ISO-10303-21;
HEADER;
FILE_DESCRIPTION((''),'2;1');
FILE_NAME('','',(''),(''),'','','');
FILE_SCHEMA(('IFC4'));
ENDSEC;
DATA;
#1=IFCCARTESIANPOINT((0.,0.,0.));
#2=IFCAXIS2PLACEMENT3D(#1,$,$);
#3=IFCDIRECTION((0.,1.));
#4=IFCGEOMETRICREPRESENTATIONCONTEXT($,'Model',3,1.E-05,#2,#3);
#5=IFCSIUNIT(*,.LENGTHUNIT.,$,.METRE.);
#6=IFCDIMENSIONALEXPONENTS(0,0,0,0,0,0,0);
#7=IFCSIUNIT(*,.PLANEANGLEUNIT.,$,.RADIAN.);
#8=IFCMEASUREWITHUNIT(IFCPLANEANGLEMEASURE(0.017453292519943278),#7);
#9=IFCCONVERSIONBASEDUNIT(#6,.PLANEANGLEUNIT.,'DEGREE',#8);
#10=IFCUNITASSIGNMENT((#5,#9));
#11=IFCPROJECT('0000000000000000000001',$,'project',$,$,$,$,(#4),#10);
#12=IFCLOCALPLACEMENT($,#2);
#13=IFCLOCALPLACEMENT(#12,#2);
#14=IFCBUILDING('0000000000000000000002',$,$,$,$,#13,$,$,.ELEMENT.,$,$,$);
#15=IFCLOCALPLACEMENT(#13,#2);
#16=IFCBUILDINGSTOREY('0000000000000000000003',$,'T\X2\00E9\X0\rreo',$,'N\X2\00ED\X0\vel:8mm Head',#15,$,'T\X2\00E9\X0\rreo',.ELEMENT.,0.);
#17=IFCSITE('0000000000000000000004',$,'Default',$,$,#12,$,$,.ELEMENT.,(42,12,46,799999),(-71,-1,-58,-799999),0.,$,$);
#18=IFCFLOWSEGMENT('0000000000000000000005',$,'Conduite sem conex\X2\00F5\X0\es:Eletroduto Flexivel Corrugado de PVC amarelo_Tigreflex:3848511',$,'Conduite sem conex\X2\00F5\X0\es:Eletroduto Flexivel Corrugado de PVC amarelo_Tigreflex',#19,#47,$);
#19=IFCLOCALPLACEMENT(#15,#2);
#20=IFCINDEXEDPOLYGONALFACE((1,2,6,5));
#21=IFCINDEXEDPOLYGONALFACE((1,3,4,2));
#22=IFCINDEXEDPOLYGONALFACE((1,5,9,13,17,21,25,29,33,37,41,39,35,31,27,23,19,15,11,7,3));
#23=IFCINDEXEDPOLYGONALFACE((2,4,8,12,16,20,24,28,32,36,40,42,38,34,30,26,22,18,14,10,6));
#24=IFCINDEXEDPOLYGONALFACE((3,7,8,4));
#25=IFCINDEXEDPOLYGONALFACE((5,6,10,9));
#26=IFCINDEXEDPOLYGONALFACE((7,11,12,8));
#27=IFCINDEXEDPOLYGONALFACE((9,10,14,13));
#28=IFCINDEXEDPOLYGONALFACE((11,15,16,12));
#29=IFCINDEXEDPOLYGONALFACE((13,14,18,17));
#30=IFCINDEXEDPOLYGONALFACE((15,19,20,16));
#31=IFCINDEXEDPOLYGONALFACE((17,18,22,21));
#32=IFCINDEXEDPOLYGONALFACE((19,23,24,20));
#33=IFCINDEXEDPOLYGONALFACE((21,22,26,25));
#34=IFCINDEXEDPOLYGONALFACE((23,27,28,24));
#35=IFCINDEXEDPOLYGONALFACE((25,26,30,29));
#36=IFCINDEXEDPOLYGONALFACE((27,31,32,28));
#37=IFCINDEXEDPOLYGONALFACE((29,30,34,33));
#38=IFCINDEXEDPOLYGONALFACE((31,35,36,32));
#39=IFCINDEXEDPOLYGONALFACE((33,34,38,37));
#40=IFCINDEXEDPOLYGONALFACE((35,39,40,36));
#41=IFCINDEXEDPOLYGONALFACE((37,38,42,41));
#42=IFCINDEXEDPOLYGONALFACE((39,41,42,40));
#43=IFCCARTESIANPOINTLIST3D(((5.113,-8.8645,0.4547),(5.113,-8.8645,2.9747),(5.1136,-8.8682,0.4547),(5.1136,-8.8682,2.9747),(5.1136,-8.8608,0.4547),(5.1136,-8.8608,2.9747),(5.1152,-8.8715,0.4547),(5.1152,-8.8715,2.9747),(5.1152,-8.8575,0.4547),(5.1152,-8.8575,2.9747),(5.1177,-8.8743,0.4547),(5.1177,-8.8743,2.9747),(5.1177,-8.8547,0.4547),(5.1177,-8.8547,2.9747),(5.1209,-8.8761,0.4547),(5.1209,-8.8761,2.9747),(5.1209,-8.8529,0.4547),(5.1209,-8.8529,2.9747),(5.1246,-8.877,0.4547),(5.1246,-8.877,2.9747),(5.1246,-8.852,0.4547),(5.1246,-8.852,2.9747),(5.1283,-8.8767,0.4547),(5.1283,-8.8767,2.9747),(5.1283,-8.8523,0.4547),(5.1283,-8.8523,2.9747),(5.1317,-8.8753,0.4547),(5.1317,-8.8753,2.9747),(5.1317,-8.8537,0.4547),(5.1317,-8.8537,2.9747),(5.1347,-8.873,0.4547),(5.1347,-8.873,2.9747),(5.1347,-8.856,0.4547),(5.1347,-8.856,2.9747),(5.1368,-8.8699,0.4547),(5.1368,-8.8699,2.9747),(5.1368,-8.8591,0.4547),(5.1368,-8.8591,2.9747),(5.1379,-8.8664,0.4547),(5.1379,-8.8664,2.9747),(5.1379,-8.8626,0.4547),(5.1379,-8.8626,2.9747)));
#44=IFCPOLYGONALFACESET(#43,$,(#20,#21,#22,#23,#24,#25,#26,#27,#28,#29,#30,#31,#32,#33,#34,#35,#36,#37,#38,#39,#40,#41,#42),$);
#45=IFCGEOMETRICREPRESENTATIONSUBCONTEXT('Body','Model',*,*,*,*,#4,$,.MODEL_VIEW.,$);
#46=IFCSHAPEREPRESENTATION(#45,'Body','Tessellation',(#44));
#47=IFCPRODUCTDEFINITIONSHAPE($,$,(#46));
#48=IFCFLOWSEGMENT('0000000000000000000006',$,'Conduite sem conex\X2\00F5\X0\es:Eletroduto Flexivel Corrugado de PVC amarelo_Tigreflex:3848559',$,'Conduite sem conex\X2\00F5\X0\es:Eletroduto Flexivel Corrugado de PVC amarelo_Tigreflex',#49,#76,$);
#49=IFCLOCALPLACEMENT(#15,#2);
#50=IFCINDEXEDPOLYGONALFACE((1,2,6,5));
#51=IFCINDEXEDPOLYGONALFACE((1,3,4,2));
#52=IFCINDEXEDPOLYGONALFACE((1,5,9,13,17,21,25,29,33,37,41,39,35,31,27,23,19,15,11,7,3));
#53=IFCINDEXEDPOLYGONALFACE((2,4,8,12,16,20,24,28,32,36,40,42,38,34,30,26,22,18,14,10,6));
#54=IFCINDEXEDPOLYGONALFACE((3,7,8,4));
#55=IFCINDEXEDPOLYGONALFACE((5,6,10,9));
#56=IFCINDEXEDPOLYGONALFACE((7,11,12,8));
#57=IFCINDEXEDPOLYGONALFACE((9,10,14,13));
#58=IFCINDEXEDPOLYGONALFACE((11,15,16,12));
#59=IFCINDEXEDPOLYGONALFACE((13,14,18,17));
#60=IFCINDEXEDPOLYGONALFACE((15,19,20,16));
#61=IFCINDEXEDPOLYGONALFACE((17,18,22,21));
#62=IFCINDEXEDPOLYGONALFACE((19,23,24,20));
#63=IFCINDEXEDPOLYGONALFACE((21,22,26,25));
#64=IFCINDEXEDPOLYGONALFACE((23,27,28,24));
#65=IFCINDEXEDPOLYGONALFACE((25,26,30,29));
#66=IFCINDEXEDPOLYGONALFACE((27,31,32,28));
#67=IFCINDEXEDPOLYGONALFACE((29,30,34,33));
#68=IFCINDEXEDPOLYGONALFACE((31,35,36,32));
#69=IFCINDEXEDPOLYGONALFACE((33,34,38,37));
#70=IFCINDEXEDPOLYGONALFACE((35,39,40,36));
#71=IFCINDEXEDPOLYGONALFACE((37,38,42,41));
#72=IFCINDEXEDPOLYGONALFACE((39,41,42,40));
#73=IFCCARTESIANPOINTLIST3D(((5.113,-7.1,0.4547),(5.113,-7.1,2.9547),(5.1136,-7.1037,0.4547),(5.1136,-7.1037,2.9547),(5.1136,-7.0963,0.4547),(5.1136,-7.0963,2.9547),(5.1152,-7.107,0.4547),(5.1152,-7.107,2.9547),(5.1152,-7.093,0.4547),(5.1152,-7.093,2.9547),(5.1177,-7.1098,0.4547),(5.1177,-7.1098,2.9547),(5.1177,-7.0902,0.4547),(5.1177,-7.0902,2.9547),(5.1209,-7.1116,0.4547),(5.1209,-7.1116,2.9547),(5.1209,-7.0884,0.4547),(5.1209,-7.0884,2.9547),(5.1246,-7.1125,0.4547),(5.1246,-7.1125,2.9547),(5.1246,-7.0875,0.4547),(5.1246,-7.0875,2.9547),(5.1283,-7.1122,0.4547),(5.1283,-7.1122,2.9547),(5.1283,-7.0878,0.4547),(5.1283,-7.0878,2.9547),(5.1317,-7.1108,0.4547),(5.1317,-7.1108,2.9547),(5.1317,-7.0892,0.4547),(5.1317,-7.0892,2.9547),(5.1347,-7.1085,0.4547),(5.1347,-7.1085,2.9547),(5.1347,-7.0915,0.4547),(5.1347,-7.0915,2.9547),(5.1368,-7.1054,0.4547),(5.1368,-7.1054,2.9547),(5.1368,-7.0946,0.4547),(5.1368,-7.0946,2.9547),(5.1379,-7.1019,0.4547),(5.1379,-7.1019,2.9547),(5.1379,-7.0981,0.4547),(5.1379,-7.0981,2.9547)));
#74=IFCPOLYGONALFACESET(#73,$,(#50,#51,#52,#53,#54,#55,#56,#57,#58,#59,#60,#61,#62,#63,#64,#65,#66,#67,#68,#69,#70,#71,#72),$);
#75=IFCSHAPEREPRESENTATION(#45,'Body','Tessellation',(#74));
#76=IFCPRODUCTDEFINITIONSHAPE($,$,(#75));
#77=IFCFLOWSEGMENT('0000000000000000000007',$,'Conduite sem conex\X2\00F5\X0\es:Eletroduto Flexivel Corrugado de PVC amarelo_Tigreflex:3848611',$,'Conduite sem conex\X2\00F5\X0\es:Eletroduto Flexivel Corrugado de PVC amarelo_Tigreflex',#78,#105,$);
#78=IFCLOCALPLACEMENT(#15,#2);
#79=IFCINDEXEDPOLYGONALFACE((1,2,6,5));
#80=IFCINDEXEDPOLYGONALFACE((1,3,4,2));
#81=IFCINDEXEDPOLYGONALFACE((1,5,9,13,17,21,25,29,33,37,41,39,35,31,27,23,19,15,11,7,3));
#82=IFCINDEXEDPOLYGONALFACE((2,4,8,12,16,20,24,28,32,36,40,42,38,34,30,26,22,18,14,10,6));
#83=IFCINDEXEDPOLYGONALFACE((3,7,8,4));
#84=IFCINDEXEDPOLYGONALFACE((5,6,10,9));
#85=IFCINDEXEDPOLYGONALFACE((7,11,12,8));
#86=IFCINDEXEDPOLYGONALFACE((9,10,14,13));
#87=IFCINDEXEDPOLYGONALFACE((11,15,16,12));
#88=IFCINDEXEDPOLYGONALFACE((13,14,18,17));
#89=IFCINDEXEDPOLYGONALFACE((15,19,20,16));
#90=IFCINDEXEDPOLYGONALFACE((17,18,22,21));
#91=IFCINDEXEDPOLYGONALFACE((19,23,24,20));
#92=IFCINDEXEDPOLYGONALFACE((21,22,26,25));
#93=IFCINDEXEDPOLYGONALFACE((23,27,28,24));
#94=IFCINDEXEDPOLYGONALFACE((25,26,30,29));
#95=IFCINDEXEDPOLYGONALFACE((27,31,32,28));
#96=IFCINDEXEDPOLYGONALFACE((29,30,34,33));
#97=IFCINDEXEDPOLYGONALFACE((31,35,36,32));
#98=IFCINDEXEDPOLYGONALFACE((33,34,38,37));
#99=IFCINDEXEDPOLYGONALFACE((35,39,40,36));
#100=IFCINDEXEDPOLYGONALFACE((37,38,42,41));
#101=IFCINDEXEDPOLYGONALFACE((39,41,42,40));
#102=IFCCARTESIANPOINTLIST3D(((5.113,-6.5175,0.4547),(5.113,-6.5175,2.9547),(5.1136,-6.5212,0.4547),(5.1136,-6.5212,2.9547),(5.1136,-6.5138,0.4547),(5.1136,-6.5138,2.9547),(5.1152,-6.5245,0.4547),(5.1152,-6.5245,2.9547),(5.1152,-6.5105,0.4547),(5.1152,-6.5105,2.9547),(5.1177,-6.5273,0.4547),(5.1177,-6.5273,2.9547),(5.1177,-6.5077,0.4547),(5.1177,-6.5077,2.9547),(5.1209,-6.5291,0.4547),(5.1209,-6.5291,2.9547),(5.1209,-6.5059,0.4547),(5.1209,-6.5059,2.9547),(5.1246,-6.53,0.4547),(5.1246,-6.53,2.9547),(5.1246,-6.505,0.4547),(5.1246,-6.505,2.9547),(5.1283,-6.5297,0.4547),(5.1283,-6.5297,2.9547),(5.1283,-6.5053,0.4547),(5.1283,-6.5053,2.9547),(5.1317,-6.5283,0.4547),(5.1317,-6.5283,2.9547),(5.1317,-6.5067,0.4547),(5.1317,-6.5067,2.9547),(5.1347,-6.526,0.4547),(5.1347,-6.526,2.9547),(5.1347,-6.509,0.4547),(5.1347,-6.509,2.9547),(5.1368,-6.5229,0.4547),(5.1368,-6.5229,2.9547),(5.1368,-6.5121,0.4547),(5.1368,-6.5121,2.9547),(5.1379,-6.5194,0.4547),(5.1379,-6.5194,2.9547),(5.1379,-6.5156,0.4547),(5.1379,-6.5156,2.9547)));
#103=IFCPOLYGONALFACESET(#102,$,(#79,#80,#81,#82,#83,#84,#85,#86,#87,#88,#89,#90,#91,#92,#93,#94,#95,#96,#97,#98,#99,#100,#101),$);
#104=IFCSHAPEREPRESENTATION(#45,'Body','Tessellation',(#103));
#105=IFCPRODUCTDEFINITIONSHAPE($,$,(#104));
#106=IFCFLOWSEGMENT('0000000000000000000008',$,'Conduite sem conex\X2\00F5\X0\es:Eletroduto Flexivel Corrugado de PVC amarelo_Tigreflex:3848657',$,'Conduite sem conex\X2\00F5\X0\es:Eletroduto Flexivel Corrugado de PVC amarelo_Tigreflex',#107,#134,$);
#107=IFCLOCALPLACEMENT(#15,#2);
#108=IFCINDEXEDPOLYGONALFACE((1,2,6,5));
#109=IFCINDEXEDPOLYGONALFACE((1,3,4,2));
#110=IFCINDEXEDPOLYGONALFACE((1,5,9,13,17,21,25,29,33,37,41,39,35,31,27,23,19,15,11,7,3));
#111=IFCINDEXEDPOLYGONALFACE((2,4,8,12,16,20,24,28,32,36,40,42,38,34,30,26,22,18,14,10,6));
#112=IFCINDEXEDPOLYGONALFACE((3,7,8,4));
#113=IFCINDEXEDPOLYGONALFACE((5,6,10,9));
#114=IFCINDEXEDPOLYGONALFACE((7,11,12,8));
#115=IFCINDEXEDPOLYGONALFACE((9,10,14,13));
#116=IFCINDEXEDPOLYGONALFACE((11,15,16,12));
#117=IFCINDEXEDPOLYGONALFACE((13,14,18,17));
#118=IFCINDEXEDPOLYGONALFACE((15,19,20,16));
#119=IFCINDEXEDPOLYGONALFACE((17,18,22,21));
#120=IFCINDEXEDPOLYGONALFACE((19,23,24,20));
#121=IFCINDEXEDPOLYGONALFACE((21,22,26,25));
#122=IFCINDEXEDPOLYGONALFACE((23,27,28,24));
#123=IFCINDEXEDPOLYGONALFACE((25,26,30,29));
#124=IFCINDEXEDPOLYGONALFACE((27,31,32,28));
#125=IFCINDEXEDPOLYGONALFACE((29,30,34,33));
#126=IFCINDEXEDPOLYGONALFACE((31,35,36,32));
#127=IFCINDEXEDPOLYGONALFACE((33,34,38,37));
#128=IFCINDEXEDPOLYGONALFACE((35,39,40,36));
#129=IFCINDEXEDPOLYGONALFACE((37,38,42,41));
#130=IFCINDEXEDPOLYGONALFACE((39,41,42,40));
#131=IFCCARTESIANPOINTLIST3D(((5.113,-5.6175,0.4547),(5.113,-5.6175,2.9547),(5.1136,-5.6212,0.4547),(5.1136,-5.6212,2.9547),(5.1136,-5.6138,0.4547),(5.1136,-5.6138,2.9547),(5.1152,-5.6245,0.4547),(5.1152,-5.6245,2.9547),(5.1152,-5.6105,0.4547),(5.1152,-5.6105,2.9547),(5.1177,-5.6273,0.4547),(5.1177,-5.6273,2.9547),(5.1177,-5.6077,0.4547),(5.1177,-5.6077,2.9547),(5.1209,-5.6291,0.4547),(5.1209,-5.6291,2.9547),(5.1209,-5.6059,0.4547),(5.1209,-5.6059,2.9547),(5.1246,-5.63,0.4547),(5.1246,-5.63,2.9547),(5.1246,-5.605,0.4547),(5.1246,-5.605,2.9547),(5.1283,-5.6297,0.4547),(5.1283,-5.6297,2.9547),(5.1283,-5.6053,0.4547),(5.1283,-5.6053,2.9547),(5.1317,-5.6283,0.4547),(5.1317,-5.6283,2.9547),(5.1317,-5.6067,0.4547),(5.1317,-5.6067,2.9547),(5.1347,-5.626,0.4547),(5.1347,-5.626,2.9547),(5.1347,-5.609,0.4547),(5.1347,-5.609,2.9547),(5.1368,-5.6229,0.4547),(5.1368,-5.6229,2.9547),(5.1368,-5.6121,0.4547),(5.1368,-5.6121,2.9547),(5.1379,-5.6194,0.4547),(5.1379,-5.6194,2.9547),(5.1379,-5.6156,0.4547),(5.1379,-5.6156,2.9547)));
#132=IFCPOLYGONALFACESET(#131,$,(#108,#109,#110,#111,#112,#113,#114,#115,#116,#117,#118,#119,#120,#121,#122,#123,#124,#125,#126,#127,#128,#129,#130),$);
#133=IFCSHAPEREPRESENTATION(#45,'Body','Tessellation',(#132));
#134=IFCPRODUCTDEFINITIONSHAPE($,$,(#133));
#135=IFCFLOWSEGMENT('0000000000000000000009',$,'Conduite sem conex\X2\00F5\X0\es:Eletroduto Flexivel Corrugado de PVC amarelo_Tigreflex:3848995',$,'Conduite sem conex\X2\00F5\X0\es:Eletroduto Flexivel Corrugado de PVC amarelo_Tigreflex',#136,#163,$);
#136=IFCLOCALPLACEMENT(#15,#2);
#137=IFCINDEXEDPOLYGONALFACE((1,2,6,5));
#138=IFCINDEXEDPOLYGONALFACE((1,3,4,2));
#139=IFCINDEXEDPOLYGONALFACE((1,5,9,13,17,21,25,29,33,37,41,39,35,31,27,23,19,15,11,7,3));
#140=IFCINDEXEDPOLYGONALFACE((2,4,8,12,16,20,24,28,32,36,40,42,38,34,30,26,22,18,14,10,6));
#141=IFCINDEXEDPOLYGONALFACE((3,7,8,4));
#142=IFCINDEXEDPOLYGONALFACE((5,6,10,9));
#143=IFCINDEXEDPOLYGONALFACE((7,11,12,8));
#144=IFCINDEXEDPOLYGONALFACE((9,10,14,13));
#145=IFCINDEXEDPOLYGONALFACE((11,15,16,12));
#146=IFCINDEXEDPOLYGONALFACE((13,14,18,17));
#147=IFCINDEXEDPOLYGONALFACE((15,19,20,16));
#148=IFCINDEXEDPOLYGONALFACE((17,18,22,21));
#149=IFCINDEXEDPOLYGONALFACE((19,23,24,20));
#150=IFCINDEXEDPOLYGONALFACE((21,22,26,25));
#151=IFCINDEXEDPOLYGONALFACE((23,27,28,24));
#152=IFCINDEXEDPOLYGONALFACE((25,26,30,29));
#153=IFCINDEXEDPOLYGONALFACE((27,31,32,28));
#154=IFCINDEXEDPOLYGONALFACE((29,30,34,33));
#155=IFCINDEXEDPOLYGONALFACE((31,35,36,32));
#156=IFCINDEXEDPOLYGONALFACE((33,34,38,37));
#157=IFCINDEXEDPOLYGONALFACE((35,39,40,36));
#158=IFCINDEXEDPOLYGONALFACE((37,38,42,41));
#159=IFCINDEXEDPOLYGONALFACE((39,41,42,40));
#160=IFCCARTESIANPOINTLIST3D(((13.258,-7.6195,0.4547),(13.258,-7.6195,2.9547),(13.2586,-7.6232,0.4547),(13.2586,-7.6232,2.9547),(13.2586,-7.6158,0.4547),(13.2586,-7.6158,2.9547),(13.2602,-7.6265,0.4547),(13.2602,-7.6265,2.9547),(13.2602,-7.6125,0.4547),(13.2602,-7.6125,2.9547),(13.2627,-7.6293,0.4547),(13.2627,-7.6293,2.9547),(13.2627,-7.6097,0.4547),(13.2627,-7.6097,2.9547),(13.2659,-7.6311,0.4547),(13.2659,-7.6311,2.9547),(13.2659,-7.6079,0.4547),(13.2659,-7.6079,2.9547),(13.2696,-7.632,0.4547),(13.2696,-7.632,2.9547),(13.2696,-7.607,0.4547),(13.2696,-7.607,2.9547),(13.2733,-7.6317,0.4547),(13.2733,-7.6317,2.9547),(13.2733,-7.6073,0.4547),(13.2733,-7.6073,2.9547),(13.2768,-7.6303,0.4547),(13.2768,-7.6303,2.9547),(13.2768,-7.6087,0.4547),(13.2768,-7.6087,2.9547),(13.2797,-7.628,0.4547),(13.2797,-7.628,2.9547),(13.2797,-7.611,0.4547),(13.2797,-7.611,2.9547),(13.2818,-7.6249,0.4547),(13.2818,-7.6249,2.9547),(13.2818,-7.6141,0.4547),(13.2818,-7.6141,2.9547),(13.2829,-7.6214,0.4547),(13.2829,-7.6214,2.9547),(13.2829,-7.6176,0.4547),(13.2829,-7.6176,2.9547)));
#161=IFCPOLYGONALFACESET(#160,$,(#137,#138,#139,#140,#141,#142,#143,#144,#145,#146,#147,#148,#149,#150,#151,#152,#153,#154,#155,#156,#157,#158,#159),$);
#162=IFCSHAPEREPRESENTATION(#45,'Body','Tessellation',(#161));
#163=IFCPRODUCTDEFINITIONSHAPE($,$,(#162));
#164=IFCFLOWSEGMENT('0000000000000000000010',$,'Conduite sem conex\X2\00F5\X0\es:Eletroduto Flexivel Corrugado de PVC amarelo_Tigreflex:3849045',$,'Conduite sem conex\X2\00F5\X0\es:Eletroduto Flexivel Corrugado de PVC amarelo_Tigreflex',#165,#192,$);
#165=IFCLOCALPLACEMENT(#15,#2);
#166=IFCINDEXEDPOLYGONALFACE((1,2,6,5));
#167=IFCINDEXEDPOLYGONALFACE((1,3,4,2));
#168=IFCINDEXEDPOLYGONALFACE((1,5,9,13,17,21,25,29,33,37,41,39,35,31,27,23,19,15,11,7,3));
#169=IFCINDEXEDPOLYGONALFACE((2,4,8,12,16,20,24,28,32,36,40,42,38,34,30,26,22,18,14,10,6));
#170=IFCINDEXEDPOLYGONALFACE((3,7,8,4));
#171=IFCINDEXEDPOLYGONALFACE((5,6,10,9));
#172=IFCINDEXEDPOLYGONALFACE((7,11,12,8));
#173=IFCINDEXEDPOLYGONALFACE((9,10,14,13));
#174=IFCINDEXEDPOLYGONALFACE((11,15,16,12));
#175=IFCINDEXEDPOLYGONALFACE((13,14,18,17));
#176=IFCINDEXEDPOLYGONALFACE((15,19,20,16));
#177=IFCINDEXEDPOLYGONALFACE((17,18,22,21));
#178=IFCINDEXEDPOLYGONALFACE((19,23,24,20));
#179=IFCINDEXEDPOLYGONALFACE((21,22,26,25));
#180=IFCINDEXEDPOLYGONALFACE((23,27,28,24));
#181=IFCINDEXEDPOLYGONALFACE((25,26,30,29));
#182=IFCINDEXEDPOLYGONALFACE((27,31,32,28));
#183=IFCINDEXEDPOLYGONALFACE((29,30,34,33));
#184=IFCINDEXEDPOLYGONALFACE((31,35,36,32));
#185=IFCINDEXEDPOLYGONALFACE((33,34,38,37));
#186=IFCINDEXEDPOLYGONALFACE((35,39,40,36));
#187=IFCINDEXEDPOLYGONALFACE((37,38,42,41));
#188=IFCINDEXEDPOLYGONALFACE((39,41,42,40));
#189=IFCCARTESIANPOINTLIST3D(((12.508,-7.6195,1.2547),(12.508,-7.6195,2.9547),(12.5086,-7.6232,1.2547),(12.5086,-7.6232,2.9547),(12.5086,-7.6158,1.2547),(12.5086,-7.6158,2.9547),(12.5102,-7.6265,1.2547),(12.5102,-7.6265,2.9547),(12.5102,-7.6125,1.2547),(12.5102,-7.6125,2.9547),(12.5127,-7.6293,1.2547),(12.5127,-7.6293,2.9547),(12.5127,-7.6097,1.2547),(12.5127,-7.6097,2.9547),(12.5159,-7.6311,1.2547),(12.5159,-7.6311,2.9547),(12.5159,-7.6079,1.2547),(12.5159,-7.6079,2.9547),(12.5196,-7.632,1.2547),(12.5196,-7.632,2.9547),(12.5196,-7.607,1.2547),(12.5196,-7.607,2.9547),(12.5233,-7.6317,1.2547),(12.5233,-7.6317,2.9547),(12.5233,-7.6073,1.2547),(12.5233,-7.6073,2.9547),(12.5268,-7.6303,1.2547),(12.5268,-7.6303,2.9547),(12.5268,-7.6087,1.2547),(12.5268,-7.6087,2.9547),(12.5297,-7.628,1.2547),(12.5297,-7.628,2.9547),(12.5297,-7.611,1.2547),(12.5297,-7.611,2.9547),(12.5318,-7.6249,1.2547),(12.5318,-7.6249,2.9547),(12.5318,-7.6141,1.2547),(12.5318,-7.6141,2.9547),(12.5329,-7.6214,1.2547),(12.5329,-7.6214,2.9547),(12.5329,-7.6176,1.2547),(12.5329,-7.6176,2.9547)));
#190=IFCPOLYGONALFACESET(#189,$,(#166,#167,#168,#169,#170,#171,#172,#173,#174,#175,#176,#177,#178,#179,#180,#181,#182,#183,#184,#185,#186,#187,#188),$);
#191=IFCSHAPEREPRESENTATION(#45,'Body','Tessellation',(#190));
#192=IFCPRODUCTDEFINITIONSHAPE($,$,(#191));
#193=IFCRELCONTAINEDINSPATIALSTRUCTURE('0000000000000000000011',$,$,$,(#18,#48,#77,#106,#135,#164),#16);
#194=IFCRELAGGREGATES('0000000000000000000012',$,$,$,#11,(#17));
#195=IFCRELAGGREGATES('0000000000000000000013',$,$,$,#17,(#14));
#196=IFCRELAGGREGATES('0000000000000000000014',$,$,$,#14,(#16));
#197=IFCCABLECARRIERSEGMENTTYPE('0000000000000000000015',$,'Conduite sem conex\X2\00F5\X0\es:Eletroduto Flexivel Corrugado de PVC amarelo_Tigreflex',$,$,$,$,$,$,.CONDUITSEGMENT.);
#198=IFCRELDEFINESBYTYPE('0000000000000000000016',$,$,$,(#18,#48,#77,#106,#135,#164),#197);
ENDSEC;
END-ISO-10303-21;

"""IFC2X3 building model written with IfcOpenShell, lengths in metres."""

from ifc_helpers import new_model, entity, si_unit, converted_unit, direction, frame, frame_2d, origin, origin_2d_with_axis, place, context, subcontext, project, spatial, circle, extrude, type_object, element, save


model = new_model("IFC2X3")

# Units and contexts
model_context = context("Model", 3, precision=1e-05, world=origin(), true_north=direction((0.0, 1.0)))
body_context = subcontext(model_context, "Body", "Model", "MODEL_VIEW")
ifc_project = project(units=[si_unit("LENGTHUNIT", "METRE"), converted_unit("PLANEANGLEUNIT", "DEGREE", entity("IfcPlaneAngleMeasure", 0.017453292519943278), si_unit("PLANEANGLEUNIT", "RADIAN"), dimensions=[0, 0, 0, 0, 0, 0, 0])], contexts=[model_context])

# Site, building, storey
site_placement = place(None, origin())
site = spatial("IfcSite", under=ifc_project, at=site_placement, Name="Default", CompositionType="ELEMENT", RefLatitude=(42, 12, 46, 799999), RefLongitude=(-71, -1, -58, -799999), RefElevation=0.0)
building_placement = place(site_placement, origin())
building = spatial("IfcBuilding", under=site, at=building_placement, CompositionType="ELEMENT")
storey_placement = place(building_placement, origin())
storey = spatial("IfcBuildingStorey", under=building, at=storey_placement, Name="Térreo", ObjectType="Nível:8mm Head", LongName="Térreo", CompositionType="ELEMENT", Elevation=0.0)

# Flow segments
cable_carrier_segment_type = type_object("IfcCableCarrierSegmentType", Name="Conduite sem conexões:Eletroduto Flexivel Corrugado de PVC amarelo_Tigreflex", PredefinedType="CONDUITSEGMENT")
flow_segment_1_placement = place(storey_placement, origin())
element("IfcFlowSegment", 1, at=flow_segment_1_placement, inside=storey, type_object=cable_carrier_segment_type, Name="Conduite sem conexões:Eletroduto Flexivel Corrugado de PVC amarelo_Tigreflex:3848511", ObjectType="Conduite sem conexões:Eletroduto Flexivel Corrugado de PVC amarelo_Tigreflex", context=body_context, shape_type="SweptSolid", body=[
    extrude(circle(Radius=0.0125, at=frame_2d((0.0, 0.0), x_axis=(1.0, 0.0))), frame((5.1255, -8.8645, 0.4547), z_axis=(0.0, 0.0, 1.0), x_axis=(-1.0, 0.0, 0.0)), (0.0, 0.0, 1.0), 2.52),
])
flow_segment_2_placement = place(storey_placement, origin())
element("IfcFlowSegment", 2, at=flow_segment_2_placement, inside=storey, type_object=cable_carrier_segment_type, Name="Conduite sem conexões:Eletroduto Flexivel Corrugado de PVC amarelo_Tigreflex:3848559", ObjectType="Conduite sem conexões:Eletroduto Flexivel Corrugado de PVC amarelo_Tigreflex", context=body_context, shape_type="SweptSolid", body=[
    extrude(circle(Radius=0.0125, at=frame_2d((0.0, 0.0), x_axis=(1.0, 0.0))), frame((5.1255, -7.1, 0.4547), z_axis=(0.0, 0.0, 1.0), x_axis=(-1.0, 0.0, 0.0)), (0.0, 0.0, 1.0), 2.5),
])
flow_segment_3_placement = place(storey_placement, origin())
element("IfcFlowSegment", 3, at=flow_segment_3_placement, inside=storey, type_object=cable_carrier_segment_type, Name="Conduite sem conexões:Eletroduto Flexivel Corrugado de PVC amarelo_Tigreflex:3848611", ObjectType="Conduite sem conexões:Eletroduto Flexivel Corrugado de PVC amarelo_Tigreflex", context=body_context, shape_type="SweptSolid", body=[
    extrude(circle(Radius=0.0125, at=origin_2d_with_axis()), frame((5.1255, -6.5175, 0.4547), z_axis=(0.0, 0.0, 1.0), x_axis=(-1.0, 0.0, 0.0)), (0.0, 0.0, 1.0), 2.5),
])
flow_segment_4_placement = place(storey_placement, origin())
element("IfcFlowSegment", 4, at=flow_segment_4_placement, inside=storey, type_object=cable_carrier_segment_type, Name="Conduite sem conexões:Eletroduto Flexivel Corrugado de PVC amarelo_Tigreflex:3848657", ObjectType="Conduite sem conexões:Eletroduto Flexivel Corrugado de PVC amarelo_Tigreflex", context=body_context, shape_type="SweptSolid", body=[
    extrude(circle(Radius=0.0125, at=origin_2d_with_axis()), frame((5.1255, -5.6175, 0.4547), z_axis=(0.0, 0.0, 1.0), x_axis=(-1.0, 0.0, 0.0)), (0.0, 0.0, 1.0), 2.5),
])
flow_segment_5_placement = place(storey_placement, origin())
element("IfcFlowSegment", 5, at=flow_segment_5_placement, inside=storey, type_object=cable_carrier_segment_type, Name="Conduite sem conexões:Eletroduto Flexivel Corrugado de PVC amarelo_Tigreflex:3848995", ObjectType="Conduite sem conexões:Eletroduto Flexivel Corrugado de PVC amarelo_Tigreflex", context=body_context, shape_type="SweptSolid", body=[
    extrude(circle(Radius=0.0125, at=frame_2d((0.0, 0.0), x_axis=(1.0, 0.0))), frame((13.2705, -7.6195, 0.4547), z_axis=(0.0, 0.0, 1.0), x_axis=(-1.0, 0.0, 0.0)), (0.0, 0.0, 1.0), 2.5),
])
flow_segment_6_placement = place(storey_placement, origin())
element("IfcFlowSegment", 6, at=flow_segment_6_placement, inside=storey, type_object=cable_carrier_segment_type, Name="Conduite sem conexões:Eletroduto Flexivel Corrugado de PVC amarelo_Tigreflex:3849045", ObjectType="Conduite sem conexões:Eletroduto Flexivel Corrugado de PVC amarelo_Tigreflex", context=body_context, shape_type="SweptSolid", body=[
    extrude(circle(Radius=0.0125, at=frame_2d((0.0, 0.0), x_axis=(1.0, 0.0))), frame((12.5205, -7.6195, 1.2547), z_axis=(0.0, 0.0, 1.0), x_axis=(-1.0, 0.0, 0.0)), (0.0, 0.0, 1.0), 1.7),
])

save(model, "model.ifc")
